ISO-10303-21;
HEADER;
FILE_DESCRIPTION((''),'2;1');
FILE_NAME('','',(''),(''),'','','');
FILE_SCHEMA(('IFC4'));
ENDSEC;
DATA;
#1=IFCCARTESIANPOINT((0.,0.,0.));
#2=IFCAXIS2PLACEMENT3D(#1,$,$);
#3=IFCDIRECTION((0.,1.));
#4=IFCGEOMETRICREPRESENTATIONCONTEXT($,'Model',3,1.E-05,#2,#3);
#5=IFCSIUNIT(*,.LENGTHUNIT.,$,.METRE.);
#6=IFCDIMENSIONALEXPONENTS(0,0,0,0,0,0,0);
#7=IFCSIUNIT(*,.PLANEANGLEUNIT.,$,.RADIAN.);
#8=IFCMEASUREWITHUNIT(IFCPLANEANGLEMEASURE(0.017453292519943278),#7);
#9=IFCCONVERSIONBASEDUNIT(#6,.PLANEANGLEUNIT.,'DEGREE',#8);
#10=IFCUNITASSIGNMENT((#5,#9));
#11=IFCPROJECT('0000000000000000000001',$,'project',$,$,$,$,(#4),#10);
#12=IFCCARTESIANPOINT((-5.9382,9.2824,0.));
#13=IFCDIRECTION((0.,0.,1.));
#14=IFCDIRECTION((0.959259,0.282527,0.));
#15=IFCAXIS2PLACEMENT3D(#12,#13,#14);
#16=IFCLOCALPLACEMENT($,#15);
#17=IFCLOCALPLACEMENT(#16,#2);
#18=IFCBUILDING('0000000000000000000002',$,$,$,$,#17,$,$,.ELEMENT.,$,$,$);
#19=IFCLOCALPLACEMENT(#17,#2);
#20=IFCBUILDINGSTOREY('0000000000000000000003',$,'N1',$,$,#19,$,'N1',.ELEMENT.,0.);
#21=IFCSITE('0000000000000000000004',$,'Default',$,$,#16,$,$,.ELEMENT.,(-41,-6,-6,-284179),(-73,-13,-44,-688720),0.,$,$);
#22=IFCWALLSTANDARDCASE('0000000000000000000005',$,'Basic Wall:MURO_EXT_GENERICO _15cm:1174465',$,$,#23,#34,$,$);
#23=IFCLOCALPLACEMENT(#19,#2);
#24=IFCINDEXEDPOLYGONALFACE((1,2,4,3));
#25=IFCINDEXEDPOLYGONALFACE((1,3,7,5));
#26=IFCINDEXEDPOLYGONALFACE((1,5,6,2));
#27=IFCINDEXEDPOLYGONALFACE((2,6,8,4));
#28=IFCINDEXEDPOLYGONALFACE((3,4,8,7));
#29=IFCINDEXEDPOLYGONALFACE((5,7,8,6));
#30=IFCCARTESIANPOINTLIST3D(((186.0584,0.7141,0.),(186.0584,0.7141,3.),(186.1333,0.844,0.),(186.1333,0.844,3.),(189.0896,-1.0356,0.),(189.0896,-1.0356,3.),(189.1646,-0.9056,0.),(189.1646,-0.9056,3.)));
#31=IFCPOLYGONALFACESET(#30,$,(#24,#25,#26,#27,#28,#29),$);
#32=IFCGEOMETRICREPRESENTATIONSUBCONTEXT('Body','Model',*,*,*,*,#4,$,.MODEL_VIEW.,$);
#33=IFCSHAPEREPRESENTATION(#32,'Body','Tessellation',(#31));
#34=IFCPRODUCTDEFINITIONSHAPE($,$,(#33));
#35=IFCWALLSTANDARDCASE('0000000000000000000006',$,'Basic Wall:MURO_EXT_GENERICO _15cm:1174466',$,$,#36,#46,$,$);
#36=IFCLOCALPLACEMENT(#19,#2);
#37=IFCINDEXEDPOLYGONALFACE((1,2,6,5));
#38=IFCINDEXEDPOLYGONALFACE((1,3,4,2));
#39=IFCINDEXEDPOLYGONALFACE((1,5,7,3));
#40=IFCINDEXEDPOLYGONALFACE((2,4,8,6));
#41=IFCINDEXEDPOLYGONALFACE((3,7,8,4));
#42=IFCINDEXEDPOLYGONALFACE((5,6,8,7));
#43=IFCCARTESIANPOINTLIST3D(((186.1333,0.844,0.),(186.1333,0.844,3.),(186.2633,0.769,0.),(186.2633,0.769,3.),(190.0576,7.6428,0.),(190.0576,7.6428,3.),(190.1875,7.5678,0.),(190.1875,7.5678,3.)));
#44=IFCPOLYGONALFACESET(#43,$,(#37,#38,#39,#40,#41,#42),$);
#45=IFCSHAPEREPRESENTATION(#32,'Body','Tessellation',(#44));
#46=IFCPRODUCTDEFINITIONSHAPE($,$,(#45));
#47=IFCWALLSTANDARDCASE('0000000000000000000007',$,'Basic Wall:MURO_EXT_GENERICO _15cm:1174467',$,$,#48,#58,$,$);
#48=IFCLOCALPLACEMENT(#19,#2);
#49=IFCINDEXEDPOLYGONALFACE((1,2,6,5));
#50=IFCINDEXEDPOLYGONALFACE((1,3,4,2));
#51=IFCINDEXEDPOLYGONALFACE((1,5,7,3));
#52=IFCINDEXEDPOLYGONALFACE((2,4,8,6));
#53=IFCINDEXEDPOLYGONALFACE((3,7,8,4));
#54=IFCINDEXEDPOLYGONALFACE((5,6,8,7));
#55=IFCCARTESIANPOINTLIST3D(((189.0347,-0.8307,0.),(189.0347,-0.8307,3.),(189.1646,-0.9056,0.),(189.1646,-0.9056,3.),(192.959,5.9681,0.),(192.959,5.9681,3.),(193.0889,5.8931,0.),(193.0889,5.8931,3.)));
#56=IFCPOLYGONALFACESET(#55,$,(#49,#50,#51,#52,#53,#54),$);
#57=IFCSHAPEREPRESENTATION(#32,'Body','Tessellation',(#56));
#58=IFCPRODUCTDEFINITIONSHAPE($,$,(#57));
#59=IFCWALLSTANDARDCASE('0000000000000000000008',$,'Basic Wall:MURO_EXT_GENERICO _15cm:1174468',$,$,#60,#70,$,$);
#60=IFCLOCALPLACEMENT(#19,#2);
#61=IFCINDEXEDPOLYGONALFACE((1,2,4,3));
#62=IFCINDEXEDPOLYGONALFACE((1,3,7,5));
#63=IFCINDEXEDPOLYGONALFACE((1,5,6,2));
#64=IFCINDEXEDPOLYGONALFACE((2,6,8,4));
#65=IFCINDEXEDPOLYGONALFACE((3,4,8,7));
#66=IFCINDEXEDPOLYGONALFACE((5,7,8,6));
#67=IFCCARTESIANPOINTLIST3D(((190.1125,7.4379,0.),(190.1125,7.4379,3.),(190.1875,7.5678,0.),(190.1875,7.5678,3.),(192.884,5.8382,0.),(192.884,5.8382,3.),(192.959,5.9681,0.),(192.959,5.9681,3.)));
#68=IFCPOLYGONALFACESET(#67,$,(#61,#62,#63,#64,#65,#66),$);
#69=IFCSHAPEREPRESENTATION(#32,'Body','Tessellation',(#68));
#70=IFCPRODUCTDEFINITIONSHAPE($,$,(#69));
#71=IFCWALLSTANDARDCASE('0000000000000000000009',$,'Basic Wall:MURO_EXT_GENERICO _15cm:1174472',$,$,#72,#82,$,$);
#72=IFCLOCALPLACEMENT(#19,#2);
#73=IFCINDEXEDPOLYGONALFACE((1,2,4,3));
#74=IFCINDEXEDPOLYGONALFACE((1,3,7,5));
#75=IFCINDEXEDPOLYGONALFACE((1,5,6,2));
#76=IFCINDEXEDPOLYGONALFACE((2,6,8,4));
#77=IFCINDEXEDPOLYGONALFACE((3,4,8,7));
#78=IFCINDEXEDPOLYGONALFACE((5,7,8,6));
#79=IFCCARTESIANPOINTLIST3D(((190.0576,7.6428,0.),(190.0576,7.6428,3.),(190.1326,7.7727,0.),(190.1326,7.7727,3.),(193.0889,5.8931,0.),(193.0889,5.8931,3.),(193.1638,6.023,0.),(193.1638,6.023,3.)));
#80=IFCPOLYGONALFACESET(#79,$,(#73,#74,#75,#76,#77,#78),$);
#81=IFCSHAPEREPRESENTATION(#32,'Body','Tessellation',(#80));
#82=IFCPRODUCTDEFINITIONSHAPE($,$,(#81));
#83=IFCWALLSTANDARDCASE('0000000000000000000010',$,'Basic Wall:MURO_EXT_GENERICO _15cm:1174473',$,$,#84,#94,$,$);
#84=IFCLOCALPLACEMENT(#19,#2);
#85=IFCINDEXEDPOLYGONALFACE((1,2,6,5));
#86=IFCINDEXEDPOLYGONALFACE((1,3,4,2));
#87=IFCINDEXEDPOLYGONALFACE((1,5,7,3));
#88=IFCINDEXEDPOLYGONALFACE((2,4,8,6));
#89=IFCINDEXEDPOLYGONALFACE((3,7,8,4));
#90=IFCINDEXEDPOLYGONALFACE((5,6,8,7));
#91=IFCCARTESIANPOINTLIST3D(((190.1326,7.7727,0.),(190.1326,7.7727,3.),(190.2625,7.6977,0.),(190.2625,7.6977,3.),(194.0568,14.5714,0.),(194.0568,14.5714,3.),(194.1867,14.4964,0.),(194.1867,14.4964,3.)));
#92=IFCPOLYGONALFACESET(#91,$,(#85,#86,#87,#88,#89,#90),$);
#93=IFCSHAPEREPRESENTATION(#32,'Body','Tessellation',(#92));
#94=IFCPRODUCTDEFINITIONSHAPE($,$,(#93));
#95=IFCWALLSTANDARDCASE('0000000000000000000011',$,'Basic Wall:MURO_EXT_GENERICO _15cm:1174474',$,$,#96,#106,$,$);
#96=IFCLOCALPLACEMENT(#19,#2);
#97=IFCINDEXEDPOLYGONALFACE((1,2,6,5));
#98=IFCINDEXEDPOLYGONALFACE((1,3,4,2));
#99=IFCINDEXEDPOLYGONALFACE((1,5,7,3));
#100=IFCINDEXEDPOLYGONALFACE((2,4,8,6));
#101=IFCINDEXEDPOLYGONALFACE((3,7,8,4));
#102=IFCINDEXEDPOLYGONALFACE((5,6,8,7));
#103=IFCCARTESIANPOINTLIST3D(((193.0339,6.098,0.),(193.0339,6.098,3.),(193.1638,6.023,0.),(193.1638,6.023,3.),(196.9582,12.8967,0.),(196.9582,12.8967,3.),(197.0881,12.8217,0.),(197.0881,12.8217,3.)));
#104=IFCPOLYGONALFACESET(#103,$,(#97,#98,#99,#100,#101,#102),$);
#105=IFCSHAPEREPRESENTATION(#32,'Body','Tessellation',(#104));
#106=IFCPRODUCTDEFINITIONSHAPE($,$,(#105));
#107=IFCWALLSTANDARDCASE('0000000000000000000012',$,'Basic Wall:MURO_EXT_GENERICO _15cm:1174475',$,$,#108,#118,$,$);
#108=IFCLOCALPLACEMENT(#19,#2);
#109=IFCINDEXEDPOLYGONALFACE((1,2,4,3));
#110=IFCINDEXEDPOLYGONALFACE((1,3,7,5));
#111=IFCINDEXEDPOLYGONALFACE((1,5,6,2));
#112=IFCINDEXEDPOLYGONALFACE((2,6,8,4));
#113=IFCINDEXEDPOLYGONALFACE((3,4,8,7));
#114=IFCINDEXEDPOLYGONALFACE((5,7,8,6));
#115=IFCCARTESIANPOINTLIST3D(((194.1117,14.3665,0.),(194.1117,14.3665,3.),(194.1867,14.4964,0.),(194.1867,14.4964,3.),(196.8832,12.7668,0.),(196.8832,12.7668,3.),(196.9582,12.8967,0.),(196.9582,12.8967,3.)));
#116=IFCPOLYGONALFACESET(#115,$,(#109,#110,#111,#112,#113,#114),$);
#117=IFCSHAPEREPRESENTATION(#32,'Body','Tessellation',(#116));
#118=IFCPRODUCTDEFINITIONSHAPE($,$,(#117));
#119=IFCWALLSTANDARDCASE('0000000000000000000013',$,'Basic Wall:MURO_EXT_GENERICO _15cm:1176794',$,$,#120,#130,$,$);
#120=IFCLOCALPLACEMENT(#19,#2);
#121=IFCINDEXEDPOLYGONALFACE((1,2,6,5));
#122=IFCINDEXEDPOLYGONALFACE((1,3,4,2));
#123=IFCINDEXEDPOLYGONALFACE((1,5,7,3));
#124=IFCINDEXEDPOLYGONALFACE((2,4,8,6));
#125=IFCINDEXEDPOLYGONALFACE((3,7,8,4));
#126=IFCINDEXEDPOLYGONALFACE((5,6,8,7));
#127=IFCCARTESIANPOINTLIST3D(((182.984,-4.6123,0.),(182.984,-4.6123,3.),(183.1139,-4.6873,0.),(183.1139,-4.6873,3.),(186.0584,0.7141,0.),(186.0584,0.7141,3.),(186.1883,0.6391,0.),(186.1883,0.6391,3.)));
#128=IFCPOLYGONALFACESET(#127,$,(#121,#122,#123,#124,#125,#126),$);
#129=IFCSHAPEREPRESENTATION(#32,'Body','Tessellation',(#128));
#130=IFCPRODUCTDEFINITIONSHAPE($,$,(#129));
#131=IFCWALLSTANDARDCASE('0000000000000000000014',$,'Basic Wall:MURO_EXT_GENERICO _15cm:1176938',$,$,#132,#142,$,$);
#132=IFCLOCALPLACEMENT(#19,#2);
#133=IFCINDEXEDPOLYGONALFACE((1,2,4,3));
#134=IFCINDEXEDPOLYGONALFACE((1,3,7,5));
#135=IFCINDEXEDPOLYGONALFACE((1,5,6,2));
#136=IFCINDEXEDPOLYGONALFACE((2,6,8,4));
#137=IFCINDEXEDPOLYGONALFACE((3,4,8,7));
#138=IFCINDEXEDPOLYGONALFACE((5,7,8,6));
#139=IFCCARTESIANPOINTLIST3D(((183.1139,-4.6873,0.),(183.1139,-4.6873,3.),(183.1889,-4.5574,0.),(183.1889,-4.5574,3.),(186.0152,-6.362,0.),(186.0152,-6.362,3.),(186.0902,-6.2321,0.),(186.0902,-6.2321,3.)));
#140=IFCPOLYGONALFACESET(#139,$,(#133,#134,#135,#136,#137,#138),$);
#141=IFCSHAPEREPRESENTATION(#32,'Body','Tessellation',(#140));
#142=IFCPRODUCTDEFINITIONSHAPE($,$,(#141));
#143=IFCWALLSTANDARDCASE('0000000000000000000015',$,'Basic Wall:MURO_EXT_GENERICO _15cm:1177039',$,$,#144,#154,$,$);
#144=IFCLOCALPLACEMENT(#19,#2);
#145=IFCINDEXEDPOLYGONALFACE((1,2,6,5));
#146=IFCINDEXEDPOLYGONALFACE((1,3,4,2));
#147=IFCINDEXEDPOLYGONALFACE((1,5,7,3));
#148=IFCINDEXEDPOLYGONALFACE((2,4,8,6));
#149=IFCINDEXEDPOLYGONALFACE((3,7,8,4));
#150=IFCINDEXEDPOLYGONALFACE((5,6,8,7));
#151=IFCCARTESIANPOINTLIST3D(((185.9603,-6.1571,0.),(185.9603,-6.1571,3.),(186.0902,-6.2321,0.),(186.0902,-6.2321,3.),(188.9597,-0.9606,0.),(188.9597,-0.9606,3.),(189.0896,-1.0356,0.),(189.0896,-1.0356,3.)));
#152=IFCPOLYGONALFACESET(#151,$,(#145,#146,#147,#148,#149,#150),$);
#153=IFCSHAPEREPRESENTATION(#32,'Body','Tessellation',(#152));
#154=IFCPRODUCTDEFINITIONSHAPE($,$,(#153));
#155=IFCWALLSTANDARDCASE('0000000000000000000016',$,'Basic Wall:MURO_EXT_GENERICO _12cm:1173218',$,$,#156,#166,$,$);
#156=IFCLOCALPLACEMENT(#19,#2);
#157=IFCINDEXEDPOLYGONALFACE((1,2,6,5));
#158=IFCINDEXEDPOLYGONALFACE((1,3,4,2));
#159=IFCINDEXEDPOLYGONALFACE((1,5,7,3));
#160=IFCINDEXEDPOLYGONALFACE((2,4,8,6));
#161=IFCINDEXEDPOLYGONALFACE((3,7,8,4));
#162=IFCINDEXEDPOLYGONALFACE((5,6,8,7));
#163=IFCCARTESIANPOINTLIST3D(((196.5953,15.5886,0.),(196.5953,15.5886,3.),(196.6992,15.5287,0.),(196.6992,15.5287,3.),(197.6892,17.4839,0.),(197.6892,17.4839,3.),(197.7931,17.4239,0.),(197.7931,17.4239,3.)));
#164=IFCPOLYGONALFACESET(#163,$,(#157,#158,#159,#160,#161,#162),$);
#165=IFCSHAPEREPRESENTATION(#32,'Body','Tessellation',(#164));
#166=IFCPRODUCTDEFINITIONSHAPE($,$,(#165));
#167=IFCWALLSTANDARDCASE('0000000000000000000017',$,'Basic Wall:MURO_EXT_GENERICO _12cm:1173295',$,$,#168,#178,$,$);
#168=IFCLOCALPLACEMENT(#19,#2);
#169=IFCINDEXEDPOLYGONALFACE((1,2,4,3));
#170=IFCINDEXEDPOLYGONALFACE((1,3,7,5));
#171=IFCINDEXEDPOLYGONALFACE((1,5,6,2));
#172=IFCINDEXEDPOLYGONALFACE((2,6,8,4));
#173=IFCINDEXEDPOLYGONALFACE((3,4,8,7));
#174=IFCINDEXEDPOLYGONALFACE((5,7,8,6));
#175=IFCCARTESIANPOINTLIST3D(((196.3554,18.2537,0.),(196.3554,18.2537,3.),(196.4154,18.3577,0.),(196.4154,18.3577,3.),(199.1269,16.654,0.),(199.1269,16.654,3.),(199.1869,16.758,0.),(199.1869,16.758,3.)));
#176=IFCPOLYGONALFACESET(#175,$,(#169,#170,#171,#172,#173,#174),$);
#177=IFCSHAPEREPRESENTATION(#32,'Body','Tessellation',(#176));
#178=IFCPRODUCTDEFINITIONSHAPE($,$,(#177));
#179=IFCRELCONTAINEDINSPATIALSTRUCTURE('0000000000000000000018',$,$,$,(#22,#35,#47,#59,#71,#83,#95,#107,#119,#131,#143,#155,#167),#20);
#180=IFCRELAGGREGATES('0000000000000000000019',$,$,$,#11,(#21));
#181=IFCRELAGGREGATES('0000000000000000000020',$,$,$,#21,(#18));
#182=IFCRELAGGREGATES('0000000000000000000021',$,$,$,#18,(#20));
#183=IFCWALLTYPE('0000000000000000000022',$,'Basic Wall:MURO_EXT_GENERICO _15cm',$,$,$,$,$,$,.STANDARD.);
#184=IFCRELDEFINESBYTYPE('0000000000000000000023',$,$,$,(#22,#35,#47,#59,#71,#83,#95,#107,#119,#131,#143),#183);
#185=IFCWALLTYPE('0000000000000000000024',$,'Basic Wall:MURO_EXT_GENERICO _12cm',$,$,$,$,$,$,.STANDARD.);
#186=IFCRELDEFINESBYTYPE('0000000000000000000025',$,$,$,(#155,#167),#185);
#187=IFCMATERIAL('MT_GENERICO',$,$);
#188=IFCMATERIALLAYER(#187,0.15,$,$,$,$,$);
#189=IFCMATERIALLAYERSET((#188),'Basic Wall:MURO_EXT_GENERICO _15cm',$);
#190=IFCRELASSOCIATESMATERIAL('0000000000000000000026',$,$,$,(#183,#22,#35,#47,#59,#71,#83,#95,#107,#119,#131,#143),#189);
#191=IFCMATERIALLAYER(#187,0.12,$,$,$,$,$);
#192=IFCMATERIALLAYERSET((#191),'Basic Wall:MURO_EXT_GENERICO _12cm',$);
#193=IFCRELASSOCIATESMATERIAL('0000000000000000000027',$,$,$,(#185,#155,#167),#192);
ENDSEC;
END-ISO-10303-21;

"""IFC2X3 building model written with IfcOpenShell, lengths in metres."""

from ifc_helpers import new_model, entity, si_unit, converted_unit, direction, frame, frame_2d, origin, place, context, subcontext, project, spatial, rectangle, extrude, material, layer, layer_set, layer_usage, type_object, element, save


model = new_model("IFC2X3")

# Units and contexts
model_context = context("Model", 3, precision=1e-05, world=origin(), true_north=direction((0.0, 1.0)))
body_context = subcontext(model_context, "Body", "Model", "MODEL_VIEW")
ifc_project = project(units=[si_unit("LENGTHUNIT", "METRE"), converted_unit("PLANEANGLEUNIT", "DEGREE", entity("IfcPlaneAngleMeasure", 0.017453292519943278), si_unit("PLANEANGLEUNIT", "RADIAN"), dimensions=[0, 0, 0, 0, 0, 0, 0])], contexts=[model_context])

# Site, building, storey
site_placement = place(None, frame((-5.9382, 9.2824, 0.0), z_axis=(0.0, 0.0, 1.0), x_axis=(0.959259, 0.282527, 0.0)))
site = spatial("IfcSite", under=ifc_project, at=site_placement, Name="Default", CompositionType="ELEMENT", RefLatitude=(-41, -6, -6, -284179), RefLongitude=(-73, -13, -44, -688720), RefElevation=0.0)
building_placement = place(site_placement, origin())
building = spatial("IfcBuilding", under=site, at=building_placement, CompositionType="ELEMENT")
storey_placement = place(building_placement, origin())
storey = spatial("IfcBuildingStorey", under=building, at=storey_placement, Name="N1", LongName="N1", CompositionType="ELEMENT", Elevation=0.0)

# Shared definitions
ifc_material_1 = material(Name="MT_GENERICO")
ifc_layer_1 = layer(ifc_material_1, 0.15)
ifc_layer_set_1 = layer_set([ifc_layer_1], Name="Basic Wall:MURO_EXT_GENERICO _15cm")
wall_type_1 = type_object("IfcWallType", Name="Basic Wall:MURO_EXT_GENERICO _15cm", PredefinedType="STANDARD", material=ifc_layer_set_1)

# Walls
ifc_layer_usage_1 = layer_usage(ifc_layer_set_1, "AXIS2", "POSITIVE", -0.075)
wall_1_placement = place(storey_placement, frame((189.1271, -0.9706, 0.0), z_axis=(0.0, 0.0, 1.0), x_axis=(-0.866082, 0.499903, 0.0)))
element("IfcWallStandardCase", 1, at=wall_1_placement, inside=storey, type_object=wall_type_1, material=ifc_layer_usage_1, Name="Basic Wall:MURO_EXT_GENERICO _15cm:1174465", context=body_context, shape_type="SweptSolid", body=[
    extrude(rectangle(XDim=3.5, YDim=0.15, at=frame_2d((1.75, 0.0), x_axis=(-1.0, 0.0))), origin(), (0.0, 0.0, 1.0), 3.0),
])
ifc_layer_usage_2 = layer_usage(ifc_layer_set_1, "AXIS2", "POSITIVE", -0.075)
wall_2_placement = place(storey_placement, frame((186.1983, 0.8065, 0.0), z_axis=(0.0, 0.0, 1.0), x_axis=(0.499903, 0.866082, 0.0)))
element("IfcWallStandardCase", 2, at=wall_2_placement, inside=storey, type_object=wall_type_1, material=ifc_layer_usage_2, Name="Basic Wall:MURO_EXT_GENERICO _15cm:1174466", context=body_context, shape_type="SweptSolid", body=[
    extrude(rectangle(XDim=7.85, YDim=0.15, at=frame_2d((3.925, 0.0), x_axis=(-1.0, 0.0))), origin(), (0.0, 0.0, 1.0), 3.0),
])
ifc_layer_usage_3 = layer_usage(ifc_layer_set_1, "AXIS2", "POSITIVE", -0.075)
wall_3_placement = place(storey_placement, frame((193.0239, 5.9306, 0.0), z_axis=(0.0, 0.0, 1.0), x_axis=(-0.499903, -0.866082, 0.0)))
element("IfcWallStandardCase", 3, at=wall_3_placement, inside=storey, type_object=wall_type_1, material=ifc_layer_usage_3, Name="Basic Wall:MURO_EXT_GENERICO _15cm:1174467", context=body_context, shape_type="SweptSolid", body=[
    extrude(rectangle(XDim=7.85, YDim=0.15, at=frame_2d((3.925, 0.0), x_axis=(-1.0, 0.0))), origin(), (0.0, 0.0, 1.0), 3.0),
])
ifc_layer_usage_4 = layer_usage(ifc_layer_set_1, "AXIS2", "POSITIVE", -0.075)
wall_4_placement = place(storey_placement, frame((190.15, 7.5028, 0.0), z_axis=(0.0, 0.0, 1.0), x_axis=(0.866082, -0.499903, 0.0)))
element("IfcWallStandardCase", 4, at=wall_4_placement, inside=storey, type_object=wall_type_1, material=ifc_layer_usage_4, Name="Basic Wall:MURO_EXT_GENERICO _15cm:1174468", context=body_context, shape_type="SweptSolid", body=[
    extrude(rectangle(XDim=3.2, YDim=0.15, at=frame_2d((1.6, 0.0), x_axis=(-1.0, 0.0))), origin(), (0.0, 0.0, 1.0), 3.0),
])
ifc_layer_usage_5 = layer_usage(ifc_layer_set_1, "AXIS2", "POSITIVE", -0.075)
wall_5_placement = place(storey_placement, frame((193.1264, 5.958, 0.0), z_axis=(0.0, 0.0, 1.0), x_axis=(-0.866082, 0.499903, 0.0)))
element("IfcWallStandardCase", 5, at=wall_5_placement, inside=storey, type_object=wall_type_1, material=ifc_layer_usage_5, Name="Basic Wall:MURO_EXT_GENERICO _15cm:1174472", context=body_context, shape_type="SweptSolid", body=[
    extrude(rectangle(XDim=3.5, YDim=0.15, at=frame_2d((1.75, 0.0), x_axis=(-1.0, 0.0))), origin(), (0.0, 0.0, 1.0), 3.0),
])
ifc_layer_usage_6 = layer_usage(ifc_layer_set_1, "AXIS2", "POSITIVE", -0.075)
wall_6_placement = place(storey_placement, frame((190.1975, 7.7352, 0.0), z_axis=(0.0, 0.0, 1.0), x_axis=(0.499903, 0.866082, 0.0)))
element("IfcWallStandardCase", 6, at=wall_6_placement, inside=storey, type_object=wall_type_1, material=ifc_layer_usage_6, Name="Basic Wall:MURO_EXT_GENERICO _15cm:1174473", context=body_context, shape_type="SweptSolid", body=[
    extrude(rectangle(XDim=7.85, YDim=0.15, at=frame_2d((3.925, 0.0), x_axis=(-1.0, 0.0))), origin(), (0.0, 0.0, 1.0), 3.0),
])
ifc_layer_usage_7 = layer_usage(ifc_layer_set_1, "AXIS2", "POSITIVE", -0.075)
wall_7_placement = place(storey_placement, frame((197.0231, 12.8592, 0.0), z_axis=(0.0, 0.0, 1.0), x_axis=(-0.499903, -0.866082, 0.0)))
element("IfcWallStandardCase", 7, at=wall_7_placement, inside=storey, type_object=wall_type_1, material=ifc_layer_usage_7, Name="Basic Wall:MURO_EXT_GENERICO _15cm:1174474", context=body_context, shape_type="SweptSolid", body=[
    extrude(rectangle(XDim=7.85, YDim=0.15, at=frame_2d((3.925, 0.0), x_axis=(-1.0, 0.0))), origin(), (0.0, 0.0, 1.0), 3.0),
])
ifc_layer_usage_8 = layer_usage(ifc_layer_set_1, "AXIS2", "POSITIVE", -0.075)
wall_8_placement = place(storey_placement, frame((194.1492, 14.4315, 0.0), z_axis=(0.0, 0.0, 1.0), x_axis=(0.866082, -0.499903, 0.0)))
element("IfcWallStandardCase", 8, at=wall_8_placement, inside=storey, type_object=wall_type_1, material=ifc_layer_usage_8, Name="Basic Wall:MURO_EXT_GENERICO _15cm:1174475", context=body_context, shape_type="SweptSolid", body=[
    extrude(rectangle(XDim=3.2, YDim=0.15, at=frame_2d((1.6, 0.0), x_axis=(-1.0, 0.0))), origin(), (0.0, 0.0, 1.0), 3.0),
])
ifc_layer_usage_9 = layer_usage(ifc_layer_set_1, "AXIS2", "NEGATIVE", 0.075)
wall_9_placement = place(storey_placement, frame((186.1233, 0.6766, 0.0), z_axis=(0.0, 0.0, 1.0), x_axis=(-0.499903, -0.866082, 0.0)))
element("IfcWallStandardCase", 9, at=wall_9_placement, inside=storey, type_object=wall_type_1, material=ifc_layer_usage_9, Name="Basic Wall:MURO_EXT_GENERICO _15cm:1176794", context=body_context, shape_type="SweptSolid", body=[
    extrude(rectangle(XDim=6.15, YDim=0.15, at=frame_2d((3.075, 0.0), x_axis=(-1.0, 0.0))), origin(), (0.0, 0.0, 1.0), 3.0),
])
ifc_layer_usage_10 = layer_usage(ifc_layer_set_1, "AXIS2", "NEGATIVE", 0.075)
wall_10_placement = place(storey_placement, frame((183.1514, -4.6223, 0.0), z_axis=(0.0, 0.0, 1.0), x_axis=(0.866082, -0.499903, 0.0)))
element("IfcWallStandardCase", 10, at=wall_10_placement, inside=storey, type_object=wall_type_1, material=ifc_layer_usage_10, Name="Basic Wall:MURO_EXT_GENERICO _15cm:1176938", context=body_context, shape_type="SweptSolid", body=[
    extrude(rectangle(XDim=3.35, YDim=0.15, at=frame_2d((1.675, 0.0), x_axis=(-1.0, 0.0))), origin(), (0.0, 0.0, 1.0), 3.0),
])
ifc_layer_usage_11 = layer_usage(ifc_layer_set_1, "AXIS2", "NEGATIVE", 0.075)
wall_11_placement = place(storey_placement, frame((186.0253, -6.1946, 0.0), z_axis=(0.0, 0.0, 1.0), x_axis=(0.499903, 0.866082, 0.0)))
element("IfcWallStandardCase", 11, at=wall_11_placement, inside=storey, type_object=wall_type_1, material=ifc_layer_usage_11, Name="Basic Wall:MURO_EXT_GENERICO _15cm:1177039", context=body_context, shape_type="SweptSolid", body=[
    extrude(rectangle(XDim=6.0, YDim=0.15, at=frame_2d((3.0, 0.0), x_axis=(-1.0, 0.0))), origin(), (0.0, 0.0, 1.0), 3.0),
])
ifc_layer_2 = layer(ifc_material_1, 0.12)
ifc_layer_set_2 = layer_set([ifc_layer_2], Name="Basic Wall:MURO_EXT_GENERICO _12cm")
ifc_layer_usage_12 = layer_usage(ifc_layer_set_2, "AXIS2", "NEGATIVE", 0.06)
wall_type_2 = type_object("IfcWallType", Name="Basic Wall:MURO_EXT_GENERICO _12cm", PredefinedType="STANDARD", material=ifc_layer_set_2)
wall_12_placement = place(storey_placement, frame((196.6472, 15.5586, 0.0), z_axis=(0.0, 0.0, 1.0), x_axis=(0.499903, 0.866082, 0.0)))
element("IfcWallStandardCase", 12, at=wall_12_placement, inside=storey, type_object=wall_type_2, material=ifc_layer_usage_12, Name="Basic Wall:MURO_EXT_GENERICO _12cm:1173218", context=body_context, shape_type="SweptSolid", body=[
    extrude(rectangle(XDim=2.1883, YDim=0.12, at=frame_2d((1.0941, 0.0), x_axis=(-1.0, 0.0))), origin(), (0.0, 0.0, 1.0), 3.0),
])
ifc_layer_usage_13 = layer_usage(ifc_layer_set_2, "AXIS2", "NEGATIVE", 0.06)
wall_13_placement = place(storey_placement, frame((196.3854, 18.3057, 0.0), z_axis=(0.0, 0.0, 1.0), x_axis=(0.866082, -0.499903, 0.0)))
element("IfcWallStandardCase", 13, at=wall_13_placement, inside=storey, type_object=wall_type_2, material=ifc_layer_usage_13, Name="Basic Wall:MURO_EXT_GENERICO _12cm:1173295", context=body_context, shape_type="SweptSolid", body=[
    extrude(rectangle(XDim=3.2, YDim=0.12, at=frame_2d((1.6, 0.0), x_axis=(-1.0, 0.0))), origin(), (0.0, 0.0, 1.0), 3.0),
])

save(model, "model.ifc")
